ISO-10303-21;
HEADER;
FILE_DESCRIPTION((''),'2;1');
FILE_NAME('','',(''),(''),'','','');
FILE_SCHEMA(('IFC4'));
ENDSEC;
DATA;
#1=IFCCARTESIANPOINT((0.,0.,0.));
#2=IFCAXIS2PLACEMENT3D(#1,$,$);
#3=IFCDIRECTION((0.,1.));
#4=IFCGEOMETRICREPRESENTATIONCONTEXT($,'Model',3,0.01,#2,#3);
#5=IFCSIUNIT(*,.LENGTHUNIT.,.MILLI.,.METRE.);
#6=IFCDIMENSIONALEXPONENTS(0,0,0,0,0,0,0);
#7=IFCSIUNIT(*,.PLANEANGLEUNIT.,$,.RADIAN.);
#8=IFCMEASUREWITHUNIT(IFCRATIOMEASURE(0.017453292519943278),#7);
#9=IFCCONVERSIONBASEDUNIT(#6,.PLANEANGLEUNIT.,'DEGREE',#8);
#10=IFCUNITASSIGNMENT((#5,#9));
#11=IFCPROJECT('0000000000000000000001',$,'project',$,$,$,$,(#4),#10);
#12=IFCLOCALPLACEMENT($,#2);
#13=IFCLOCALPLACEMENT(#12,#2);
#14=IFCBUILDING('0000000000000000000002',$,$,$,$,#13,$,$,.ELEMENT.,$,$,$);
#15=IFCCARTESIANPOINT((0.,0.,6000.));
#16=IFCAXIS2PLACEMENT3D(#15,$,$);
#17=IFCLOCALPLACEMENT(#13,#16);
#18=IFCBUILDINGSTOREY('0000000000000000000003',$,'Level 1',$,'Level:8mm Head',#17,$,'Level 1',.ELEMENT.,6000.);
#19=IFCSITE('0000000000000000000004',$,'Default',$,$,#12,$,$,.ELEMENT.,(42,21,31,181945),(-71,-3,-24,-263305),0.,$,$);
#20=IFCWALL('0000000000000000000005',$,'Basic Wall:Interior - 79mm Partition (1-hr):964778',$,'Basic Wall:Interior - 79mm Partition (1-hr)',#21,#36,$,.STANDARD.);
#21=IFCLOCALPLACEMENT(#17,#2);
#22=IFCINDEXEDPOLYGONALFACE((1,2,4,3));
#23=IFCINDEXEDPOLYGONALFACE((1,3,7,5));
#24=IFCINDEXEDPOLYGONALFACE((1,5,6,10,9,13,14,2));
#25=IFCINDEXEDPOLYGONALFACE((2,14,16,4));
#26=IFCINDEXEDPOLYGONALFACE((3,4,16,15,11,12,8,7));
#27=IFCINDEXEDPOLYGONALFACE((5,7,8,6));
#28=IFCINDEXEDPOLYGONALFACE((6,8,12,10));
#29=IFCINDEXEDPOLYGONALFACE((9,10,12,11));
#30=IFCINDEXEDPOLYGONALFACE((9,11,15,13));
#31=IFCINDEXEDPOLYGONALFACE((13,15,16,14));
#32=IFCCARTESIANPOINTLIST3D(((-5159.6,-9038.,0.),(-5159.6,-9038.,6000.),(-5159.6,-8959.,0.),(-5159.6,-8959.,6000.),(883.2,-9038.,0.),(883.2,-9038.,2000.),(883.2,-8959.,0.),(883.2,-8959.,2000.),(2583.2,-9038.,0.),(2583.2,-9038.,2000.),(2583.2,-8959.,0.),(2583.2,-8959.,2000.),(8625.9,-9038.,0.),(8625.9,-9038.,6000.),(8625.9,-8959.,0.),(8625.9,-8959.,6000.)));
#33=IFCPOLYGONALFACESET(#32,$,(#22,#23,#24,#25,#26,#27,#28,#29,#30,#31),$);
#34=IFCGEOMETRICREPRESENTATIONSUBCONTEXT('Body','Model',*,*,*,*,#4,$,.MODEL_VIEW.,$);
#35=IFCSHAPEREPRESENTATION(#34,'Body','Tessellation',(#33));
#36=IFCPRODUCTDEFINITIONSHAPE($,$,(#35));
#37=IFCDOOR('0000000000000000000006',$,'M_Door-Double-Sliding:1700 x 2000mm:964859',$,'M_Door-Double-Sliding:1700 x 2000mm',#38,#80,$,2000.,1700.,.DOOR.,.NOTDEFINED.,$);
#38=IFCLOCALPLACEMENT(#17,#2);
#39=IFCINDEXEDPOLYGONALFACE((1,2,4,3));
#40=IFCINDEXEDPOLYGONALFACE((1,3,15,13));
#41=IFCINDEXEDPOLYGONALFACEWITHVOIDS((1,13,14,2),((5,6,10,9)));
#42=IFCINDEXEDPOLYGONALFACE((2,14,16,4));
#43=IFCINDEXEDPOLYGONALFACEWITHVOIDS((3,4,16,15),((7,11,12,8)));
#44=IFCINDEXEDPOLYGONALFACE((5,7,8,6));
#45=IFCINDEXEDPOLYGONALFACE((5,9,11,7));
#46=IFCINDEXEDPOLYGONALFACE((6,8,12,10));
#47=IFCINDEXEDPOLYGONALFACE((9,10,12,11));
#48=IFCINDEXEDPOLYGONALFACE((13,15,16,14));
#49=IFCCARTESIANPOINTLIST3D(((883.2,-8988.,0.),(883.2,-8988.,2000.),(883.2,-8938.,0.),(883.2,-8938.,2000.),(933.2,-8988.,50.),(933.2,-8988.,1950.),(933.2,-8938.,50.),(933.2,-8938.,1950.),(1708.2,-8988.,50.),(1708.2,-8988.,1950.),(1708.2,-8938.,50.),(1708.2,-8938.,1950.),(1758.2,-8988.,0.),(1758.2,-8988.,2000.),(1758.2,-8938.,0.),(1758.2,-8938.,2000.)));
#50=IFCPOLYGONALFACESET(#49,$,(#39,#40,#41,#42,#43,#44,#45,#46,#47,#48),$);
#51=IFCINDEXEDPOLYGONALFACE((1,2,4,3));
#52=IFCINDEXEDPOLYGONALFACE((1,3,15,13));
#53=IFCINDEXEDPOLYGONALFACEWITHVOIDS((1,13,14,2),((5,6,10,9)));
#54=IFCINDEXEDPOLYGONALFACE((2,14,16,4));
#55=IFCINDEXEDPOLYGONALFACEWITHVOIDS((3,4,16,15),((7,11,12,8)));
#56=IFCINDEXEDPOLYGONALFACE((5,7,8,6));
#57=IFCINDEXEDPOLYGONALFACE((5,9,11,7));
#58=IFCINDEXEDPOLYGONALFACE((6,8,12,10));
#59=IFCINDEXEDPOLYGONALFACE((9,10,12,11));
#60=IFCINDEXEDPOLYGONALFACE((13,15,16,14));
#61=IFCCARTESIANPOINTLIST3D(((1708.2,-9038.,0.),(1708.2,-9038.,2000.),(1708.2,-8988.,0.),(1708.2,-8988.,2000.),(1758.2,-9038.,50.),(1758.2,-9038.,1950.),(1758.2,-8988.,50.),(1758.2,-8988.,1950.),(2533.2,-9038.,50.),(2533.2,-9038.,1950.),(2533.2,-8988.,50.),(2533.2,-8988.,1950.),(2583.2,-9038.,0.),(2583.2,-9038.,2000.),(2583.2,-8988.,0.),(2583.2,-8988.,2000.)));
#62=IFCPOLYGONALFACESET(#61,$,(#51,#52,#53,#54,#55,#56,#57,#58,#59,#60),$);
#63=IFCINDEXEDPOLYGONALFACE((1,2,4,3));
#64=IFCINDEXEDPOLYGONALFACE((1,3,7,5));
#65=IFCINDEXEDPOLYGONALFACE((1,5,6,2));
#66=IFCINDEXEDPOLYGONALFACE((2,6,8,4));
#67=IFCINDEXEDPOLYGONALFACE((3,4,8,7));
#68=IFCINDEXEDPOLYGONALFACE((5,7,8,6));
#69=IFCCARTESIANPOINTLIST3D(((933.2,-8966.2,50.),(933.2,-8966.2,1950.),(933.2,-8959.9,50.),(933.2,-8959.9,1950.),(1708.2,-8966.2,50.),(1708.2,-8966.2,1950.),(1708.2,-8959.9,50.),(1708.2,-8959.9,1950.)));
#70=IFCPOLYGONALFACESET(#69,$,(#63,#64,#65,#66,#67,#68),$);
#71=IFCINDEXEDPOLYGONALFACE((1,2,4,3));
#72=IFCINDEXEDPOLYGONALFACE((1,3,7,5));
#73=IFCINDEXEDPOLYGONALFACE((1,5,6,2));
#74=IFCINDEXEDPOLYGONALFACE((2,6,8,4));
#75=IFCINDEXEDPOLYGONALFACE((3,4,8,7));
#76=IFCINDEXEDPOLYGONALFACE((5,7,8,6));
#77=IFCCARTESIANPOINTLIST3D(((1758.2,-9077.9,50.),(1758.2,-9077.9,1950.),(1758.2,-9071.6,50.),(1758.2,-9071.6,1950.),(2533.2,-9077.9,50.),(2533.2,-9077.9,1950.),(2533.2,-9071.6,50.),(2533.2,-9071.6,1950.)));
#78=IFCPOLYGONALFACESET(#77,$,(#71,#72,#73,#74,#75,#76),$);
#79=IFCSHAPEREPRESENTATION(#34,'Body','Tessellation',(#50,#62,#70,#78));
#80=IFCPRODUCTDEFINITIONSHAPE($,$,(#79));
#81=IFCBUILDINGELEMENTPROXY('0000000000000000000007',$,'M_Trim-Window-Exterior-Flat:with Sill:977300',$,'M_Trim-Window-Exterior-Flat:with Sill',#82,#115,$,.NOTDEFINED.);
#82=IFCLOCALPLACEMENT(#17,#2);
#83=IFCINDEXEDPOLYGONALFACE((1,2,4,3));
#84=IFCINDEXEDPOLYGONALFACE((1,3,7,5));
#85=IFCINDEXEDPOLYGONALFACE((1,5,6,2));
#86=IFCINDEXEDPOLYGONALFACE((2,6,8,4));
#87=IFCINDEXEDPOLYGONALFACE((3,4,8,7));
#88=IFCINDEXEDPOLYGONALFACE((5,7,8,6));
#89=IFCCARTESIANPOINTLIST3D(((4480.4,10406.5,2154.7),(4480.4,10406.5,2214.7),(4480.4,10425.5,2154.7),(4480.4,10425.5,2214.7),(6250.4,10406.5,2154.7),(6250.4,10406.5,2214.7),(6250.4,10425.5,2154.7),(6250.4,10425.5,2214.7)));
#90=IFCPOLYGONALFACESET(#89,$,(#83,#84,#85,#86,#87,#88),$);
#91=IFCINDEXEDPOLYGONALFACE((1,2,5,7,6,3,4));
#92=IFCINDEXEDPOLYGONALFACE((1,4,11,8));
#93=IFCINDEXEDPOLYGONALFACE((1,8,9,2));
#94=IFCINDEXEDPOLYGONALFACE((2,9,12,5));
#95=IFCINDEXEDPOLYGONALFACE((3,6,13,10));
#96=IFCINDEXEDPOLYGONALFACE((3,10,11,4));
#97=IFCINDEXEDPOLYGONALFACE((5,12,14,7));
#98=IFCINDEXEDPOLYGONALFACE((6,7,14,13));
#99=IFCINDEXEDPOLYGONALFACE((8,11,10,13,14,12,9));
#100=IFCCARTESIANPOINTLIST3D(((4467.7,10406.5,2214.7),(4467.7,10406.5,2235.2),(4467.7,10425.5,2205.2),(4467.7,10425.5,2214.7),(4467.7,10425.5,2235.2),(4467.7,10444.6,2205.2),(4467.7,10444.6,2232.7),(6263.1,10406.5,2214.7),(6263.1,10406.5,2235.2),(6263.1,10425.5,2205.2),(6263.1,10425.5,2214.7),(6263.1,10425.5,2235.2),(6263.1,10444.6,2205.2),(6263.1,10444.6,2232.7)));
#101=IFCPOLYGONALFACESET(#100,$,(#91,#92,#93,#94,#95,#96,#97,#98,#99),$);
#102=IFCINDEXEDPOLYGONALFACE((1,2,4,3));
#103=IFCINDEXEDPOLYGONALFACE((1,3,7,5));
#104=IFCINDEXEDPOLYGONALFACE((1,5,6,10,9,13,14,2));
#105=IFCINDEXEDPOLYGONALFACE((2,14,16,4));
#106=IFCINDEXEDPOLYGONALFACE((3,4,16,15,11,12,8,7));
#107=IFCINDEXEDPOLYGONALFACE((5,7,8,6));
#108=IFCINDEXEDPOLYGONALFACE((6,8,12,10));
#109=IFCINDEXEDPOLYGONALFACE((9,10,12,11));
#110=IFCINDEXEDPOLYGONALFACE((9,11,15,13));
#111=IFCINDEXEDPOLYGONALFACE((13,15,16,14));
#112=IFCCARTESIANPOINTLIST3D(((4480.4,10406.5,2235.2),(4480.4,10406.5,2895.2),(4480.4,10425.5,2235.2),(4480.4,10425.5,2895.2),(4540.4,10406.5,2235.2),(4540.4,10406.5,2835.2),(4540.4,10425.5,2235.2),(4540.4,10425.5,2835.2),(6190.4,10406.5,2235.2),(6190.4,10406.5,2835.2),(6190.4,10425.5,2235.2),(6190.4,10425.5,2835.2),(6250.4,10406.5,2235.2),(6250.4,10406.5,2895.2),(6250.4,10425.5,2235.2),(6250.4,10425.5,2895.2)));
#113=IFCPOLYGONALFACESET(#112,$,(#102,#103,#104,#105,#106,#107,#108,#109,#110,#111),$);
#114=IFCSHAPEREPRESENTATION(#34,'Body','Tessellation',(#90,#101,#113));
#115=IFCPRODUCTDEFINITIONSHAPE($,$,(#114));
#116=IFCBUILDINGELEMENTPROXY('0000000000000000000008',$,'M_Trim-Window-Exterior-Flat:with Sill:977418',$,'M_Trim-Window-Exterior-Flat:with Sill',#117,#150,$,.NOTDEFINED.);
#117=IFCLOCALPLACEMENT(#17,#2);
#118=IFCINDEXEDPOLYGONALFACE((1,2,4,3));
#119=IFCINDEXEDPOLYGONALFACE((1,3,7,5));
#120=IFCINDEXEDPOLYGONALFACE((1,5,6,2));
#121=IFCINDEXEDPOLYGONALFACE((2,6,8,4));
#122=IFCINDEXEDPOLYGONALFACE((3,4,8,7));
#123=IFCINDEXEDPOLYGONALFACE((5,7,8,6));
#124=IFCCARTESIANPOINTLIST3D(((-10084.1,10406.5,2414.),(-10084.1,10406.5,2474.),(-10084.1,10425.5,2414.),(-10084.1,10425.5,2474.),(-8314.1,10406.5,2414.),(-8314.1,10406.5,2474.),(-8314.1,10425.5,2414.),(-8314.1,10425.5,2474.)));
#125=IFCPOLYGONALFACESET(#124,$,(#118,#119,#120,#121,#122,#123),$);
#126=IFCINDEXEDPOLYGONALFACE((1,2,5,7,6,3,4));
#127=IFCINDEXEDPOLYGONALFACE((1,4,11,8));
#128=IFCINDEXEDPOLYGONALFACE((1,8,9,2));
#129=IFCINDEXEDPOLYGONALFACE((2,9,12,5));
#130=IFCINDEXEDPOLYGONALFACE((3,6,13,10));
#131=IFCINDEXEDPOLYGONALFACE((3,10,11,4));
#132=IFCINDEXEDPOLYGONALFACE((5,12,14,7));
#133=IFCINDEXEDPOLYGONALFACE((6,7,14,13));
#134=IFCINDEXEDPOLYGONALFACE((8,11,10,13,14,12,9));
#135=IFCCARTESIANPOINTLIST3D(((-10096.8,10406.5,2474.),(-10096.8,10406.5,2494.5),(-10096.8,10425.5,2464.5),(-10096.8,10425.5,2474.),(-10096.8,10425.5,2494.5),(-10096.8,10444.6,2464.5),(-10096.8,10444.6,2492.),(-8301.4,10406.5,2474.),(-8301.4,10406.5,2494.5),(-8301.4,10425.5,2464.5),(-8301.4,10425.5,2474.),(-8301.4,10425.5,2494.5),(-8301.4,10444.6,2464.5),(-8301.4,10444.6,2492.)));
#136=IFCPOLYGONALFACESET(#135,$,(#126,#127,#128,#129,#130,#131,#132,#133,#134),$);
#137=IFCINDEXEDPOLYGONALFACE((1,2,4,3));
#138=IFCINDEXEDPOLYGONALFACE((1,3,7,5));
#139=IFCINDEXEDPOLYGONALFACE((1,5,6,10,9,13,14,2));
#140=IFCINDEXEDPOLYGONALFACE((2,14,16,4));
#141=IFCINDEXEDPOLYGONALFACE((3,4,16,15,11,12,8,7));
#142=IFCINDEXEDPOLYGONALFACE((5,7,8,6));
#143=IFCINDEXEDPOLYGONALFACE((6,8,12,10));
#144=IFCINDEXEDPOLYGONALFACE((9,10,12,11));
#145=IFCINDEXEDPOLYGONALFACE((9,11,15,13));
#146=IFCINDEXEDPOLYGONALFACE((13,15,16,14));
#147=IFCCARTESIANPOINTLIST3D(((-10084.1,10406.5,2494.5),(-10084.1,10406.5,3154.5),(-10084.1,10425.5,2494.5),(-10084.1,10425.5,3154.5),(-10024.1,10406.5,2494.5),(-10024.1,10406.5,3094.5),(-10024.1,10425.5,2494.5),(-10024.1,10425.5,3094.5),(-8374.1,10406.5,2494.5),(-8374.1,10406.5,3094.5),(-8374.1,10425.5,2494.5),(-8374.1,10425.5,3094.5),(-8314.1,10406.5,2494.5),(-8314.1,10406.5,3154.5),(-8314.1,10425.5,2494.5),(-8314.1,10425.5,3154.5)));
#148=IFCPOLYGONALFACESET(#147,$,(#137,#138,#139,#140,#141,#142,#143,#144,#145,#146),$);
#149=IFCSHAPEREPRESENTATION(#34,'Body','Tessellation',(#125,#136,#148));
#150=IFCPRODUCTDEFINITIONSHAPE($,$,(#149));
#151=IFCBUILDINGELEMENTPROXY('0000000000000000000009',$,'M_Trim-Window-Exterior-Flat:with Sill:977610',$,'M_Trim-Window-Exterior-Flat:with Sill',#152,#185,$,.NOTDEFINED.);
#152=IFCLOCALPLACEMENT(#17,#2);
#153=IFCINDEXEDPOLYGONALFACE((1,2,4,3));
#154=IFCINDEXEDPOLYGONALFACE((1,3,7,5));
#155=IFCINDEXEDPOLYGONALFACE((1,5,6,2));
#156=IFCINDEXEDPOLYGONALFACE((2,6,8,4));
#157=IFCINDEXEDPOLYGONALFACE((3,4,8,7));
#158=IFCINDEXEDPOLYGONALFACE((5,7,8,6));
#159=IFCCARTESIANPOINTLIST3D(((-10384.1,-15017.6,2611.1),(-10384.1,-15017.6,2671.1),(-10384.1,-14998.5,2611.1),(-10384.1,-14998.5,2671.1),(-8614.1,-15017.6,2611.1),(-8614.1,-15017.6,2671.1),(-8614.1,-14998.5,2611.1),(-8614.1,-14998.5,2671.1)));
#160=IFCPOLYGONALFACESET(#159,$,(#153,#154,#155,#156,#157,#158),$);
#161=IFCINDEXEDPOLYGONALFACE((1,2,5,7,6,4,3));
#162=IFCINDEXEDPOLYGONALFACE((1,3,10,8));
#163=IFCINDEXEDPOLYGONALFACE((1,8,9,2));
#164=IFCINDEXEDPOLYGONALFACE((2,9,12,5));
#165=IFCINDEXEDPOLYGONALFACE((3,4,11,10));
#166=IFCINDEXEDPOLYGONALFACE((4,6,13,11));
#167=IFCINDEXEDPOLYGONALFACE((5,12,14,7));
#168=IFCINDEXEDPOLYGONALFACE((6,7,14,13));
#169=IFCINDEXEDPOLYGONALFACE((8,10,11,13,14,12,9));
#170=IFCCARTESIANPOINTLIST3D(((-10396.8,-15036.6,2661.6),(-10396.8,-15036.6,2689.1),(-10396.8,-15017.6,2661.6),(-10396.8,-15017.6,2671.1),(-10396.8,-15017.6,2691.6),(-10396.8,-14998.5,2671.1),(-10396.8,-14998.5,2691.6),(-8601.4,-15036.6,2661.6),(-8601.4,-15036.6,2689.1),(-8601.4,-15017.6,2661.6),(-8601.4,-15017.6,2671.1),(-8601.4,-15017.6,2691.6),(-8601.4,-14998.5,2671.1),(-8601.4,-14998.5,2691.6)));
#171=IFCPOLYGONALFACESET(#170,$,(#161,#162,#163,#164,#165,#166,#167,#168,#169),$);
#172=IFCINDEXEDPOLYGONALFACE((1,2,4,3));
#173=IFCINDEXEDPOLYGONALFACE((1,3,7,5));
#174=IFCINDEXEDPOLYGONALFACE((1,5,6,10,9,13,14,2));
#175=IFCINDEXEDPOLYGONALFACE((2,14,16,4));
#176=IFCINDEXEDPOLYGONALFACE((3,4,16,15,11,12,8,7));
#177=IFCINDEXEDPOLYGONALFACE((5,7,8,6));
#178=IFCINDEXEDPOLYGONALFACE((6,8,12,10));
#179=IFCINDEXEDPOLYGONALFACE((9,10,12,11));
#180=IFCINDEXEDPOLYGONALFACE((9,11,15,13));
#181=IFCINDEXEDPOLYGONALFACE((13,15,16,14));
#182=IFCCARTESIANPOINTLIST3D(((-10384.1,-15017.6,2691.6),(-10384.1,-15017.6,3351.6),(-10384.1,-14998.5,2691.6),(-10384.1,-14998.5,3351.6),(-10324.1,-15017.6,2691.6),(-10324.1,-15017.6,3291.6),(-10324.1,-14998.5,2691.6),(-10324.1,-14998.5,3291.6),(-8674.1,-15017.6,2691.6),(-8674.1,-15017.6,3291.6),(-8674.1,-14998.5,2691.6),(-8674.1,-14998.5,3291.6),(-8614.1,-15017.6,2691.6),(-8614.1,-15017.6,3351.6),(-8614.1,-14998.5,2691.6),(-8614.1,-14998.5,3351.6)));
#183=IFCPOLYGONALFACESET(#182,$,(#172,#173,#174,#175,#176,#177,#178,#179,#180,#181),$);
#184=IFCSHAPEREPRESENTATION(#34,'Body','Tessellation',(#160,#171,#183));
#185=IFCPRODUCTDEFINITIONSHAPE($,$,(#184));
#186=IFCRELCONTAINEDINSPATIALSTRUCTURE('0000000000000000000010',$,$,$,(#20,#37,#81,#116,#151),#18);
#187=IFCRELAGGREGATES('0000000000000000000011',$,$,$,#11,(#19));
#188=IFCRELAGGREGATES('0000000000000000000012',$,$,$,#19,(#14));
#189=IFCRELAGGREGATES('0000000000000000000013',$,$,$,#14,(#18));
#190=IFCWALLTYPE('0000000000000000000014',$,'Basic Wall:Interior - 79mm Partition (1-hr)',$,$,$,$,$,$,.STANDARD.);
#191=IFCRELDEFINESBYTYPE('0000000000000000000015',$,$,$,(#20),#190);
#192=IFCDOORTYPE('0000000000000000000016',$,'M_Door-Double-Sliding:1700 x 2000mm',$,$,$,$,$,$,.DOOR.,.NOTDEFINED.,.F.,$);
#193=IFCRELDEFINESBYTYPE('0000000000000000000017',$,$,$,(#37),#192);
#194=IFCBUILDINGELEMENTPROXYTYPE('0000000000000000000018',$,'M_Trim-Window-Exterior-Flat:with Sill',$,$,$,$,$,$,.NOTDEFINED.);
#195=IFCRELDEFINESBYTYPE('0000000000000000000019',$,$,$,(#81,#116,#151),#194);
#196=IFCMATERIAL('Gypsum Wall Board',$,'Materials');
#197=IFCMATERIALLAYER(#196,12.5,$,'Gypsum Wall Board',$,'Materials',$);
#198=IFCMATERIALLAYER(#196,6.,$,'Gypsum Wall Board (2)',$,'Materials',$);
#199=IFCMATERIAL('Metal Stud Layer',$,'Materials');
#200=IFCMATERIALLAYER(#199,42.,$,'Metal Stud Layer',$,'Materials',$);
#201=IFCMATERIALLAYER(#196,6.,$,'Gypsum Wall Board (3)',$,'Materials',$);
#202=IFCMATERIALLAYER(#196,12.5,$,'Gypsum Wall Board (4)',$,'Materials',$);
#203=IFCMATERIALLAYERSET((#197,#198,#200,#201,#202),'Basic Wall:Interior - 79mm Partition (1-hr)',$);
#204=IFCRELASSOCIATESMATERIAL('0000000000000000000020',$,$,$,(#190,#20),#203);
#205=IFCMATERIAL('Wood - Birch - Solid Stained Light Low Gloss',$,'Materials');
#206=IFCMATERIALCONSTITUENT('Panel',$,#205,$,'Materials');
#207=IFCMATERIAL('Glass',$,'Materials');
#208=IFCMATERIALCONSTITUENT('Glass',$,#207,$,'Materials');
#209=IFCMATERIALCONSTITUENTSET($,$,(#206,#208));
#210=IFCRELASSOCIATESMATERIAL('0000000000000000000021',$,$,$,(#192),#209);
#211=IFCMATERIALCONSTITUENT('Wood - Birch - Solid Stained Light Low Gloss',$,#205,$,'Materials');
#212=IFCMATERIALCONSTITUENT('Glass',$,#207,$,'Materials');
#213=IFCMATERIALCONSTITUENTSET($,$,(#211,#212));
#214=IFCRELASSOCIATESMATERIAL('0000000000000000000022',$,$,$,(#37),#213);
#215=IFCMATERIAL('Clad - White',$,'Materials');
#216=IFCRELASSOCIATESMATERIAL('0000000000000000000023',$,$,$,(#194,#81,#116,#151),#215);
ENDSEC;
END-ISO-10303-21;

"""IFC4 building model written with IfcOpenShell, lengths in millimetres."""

from ifc_helpers import new_model, entity, si_unit, converted_unit, direction, frame, frame_2d, origin, origin_2d_with_axis, place, context, subcontext, project, spatial, polyline, rectangle, outline, extrude, source, transform, mapped, material, layer, layer_set, layer_usage, constituent, constituent_set, type_object, type_shapes, element, fill, save


model = new_model("IFC4")

# Units and contexts
model_context = context("Model", 3, precision=0.01, world=origin(), true_north=direction((0.0, 1.0)))
body_context = subcontext(model_context, "Body", "Model", "MODEL_VIEW")
ifc_project = project(units=[si_unit("LENGTHUNIT", "METRE", prefix="MILLI"), converted_unit("PLANEANGLEUNIT", "DEGREE", entity("IfcRatioMeasure", 0.017453292519943278), si_unit("PLANEANGLEUNIT", "RADIAN"), dimensions=[0, 0, 0, 0, 0, 0, 0])], contexts=[model_context])

# Site, building, storey
site_placement = place(None, origin())
site = spatial("IfcSite", under=ifc_project, at=site_placement, Name="Default", CompositionType="ELEMENT", RefLatitude=(42, 21, 31, 181945), RefLongitude=(-71, -3, -24, -263305), RefElevation=0.0)
building_placement = place(site_placement, origin())
building = spatial("IfcBuilding", under=site, at=building_placement, CompositionType="ELEMENT")
storey_placement = place(building_placement, frame((0.0, 0.0, 6000.0)))
storey = spatial("IfcBuildingStorey", under=building, at=storey_placement, Name="Level 1", ObjectType="Level:8mm Head", LongName="Level 1", CompositionType="ELEMENT", Elevation=6000.0)

# Shared definitions
ifc_material_1 = material(Name="Gypsum Wall Board", Category="Materials")
ifc_layer_1 = layer(ifc_material_1, 12.5, Name="Gypsum Wall Board", Category="Materials")
ifc_layer_2 = layer(ifc_material_1, 6.0, Name="Gypsum Wall Board (2)", Category="Materials")
ifc_material_2 = material(Name="Metal Stud Layer", Category="Materials")
ifc_layer_3 = layer(ifc_material_2, 42.0, Name="Metal Stud Layer", Category="Materials")
ifc_layer_4 = layer(ifc_material_1, 6.0, Name="Gypsum Wall Board (3)", Category="Materials")
ifc_layer_5 = layer(ifc_material_1, 12.5, Name="Gypsum Wall Board (4)", Category="Materials")
ifc_layer_set_1 = layer_set([ifc_layer_1, ifc_layer_2, ifc_layer_3, ifc_layer_4, ifc_layer_5], Name="Basic Wall:Interior - 79mm Partition (1-hr)")
ifc_layer_usage_1 = layer_usage(ifc_layer_set_1, "AXIS2", "NEGATIVE", 39.5)
wall_type = type_object("IfcWallType", Name="Basic Wall:Interior - 79mm Partition (1-hr)", PredefinedType="STANDARD", material=ifc_layer_set_1)

# Wall, opening, door
ifc_material_3 = material(Name="Wood - Birch - Solid Stained Light Low Gloss", Category="Materials")
ifc_material_4 = material(Name="Glass", Category="Materials")
ifc_constituent_1 = constituent(ifc_material_3, Name="Panel", Category="Materials")
ifc_constituent_2 = constituent(ifc_material_4, Name="Glass", Category="Materials")
ifc_constituent_set_1 = constituent_set(constituents=[ifc_constituent_1, ifc_constituent_2])
door_type = type_object("IfcDoorType", Name="M_Door-Double-Sliding:1700 x 2000mm", OperationType="NOTDEFINED", ParameterTakesPrecedence=False, PredefinedType="DOOR", material=ifc_constituent_set_1)
shared_shape_1 = source(origin(), body_context, "Body", "SweptSolid", [
    extrude(outline(polyline([(-437.5, -1000.0), (437.5, -1000.0), (437.5, 1000.0), (-437.5, 1000.0), (-437.5, -1000.0)]), holes=[polyline([(-387.5, -950.0), (-387.5, 950.0), (387.5, 950.0), (387.5, -950.0), (-387.5, -950.0)])]), frame((1262.5, -21.0, 1000.0), z_axis=(0.0, 1.0, 0.0), x_axis=(1.0, 0.0, 0.0)), (0.0, 0.0, 1.0), 50.0),
    extrude(outline(polyline([(-1000.0, -437.5), (1000.0, -437.5), (1000.0, 437.5), (-1000.0, 437.5), (-1000.0, -437.5)]), holes=[polyline([(-950.0, -387.5), (-950.0, 387.5), (950.0, 387.5), (950.0, -387.5), (-950.0, -387.5)])]), frame((437.5, 29.0, 1000.0), z_axis=(0.0, 1.0, 0.0), x_axis=(0.0, 0.0, -1.0)), (0.0, 0.0, 1.0), 50.0),
    extrude(rectangle(XDim=6.3, YDim=775.0, at=frame_2d((0.0, 0.0), x_axis=(1.0, 0.0))), frame((1262.5, 4.0, 50.0), z_axis=(0.0, 0.0, 1.0), x_axis=(0.0, -1.0, 0.0)), (0.0, 0.0, 1.0), 1900.0),
    extrude(rectangle(XDim=6.4, YDim=775.0, at=origin_2d_with_axis()), frame((437.5, 115.7, 50.0), z_axis=(0.0, 0.0, 1.0), x_axis=(0.0, 1.0, 0.0)), (0.0, 0.0, 1.0), 1900.0),
])
type_shapes(door_type, [shared_shape_1])
wall_1_placement = place(storey_placement, frame((-5159.6, -8998.5, 0.0)))
wall_1 = element("IfcWall", 1, at=wall_1_placement, inside=storey, type_object=wall_type, material=ifc_layer_usage_1, Name="Basic Wall:Interior - 79mm Partition (1-hr):964778", ObjectType="Basic Wall:Interior - 79mm Partition (1-hr)", PredefinedType="STANDARD", context=body_context, shape_type="SweptSolid", body=[
    extrude(rectangle(XDim=13785.5, YDim=79.0, at=frame_2d((6892.8, 0.0), x_axis=(1.0, 0.0))), origin(), (0.0, 0.0, 1.0), 6000.0),
])
opening_1_placement = place(wall_1_placement, frame((7742.8, 39.5, 0.0)))
opening_1 = element("IfcOpeningElement", 2, at=opening_1_placement, cuts=wall_1, PredefinedType="OPENING", context=body_context, shape_type="SweptSolid", body=[
    extrude(rectangle(XDim=2000.0, YDim=1700.0, at=frame_2d((1000.0, 850.0), x_axis=(-1.0, 0.0))), frame((0.0, 0.0, 0.0), z_axis=(0.0, -1.0, 0.0), x_axis=(0.0, 0.0, 1.0)), (0.0, 0.0, 1.0), 79.0),
])
ifc_constituent_3 = constituent(ifc_material_3, Name="Wood - Birch - Solid Stained Light Low Gloss", Category="Materials")
ifc_constituent_4 = constituent(ifc_material_4, Name="Glass", Category="Materials")
ifc_constituent_set_2 = constituent_set(constituents=[ifc_constituent_3, ifc_constituent_4])
door_1_placement = place(opening_1_placement, frame((0.0, 0.0, 0.0), z_axis=(0.0, 0.0, 1.0), x_axis=(-1.0, 0.0, 0.0)))
door_1 = element("IfcDoor", 3, at=door_1_placement, inside=storey, type_object=door_type, material=ifc_constituent_set_2, Name="M_Door-Double-Sliding:1700 x 2000mm:964859", ObjectType="M_Door-Double-Sliding:1700 x 2000mm", OperationType="NOTDEFINED", OverallHeight=2000.0, OverallWidth=1700.0, PredefinedType="DOOR", context=body_context, shape_type="MappedRepresentation", body=[
    mapped(shared_shape_1, transform((0.0, 0.0, 0.0), scale=1.0)),
])
fill(opening_1, door_1)

# Building element proxies
ifc_material_5 = material(Name="Clad - White", Category="Materials")
building_element_proxy_type_1 = type_object("IfcBuildingElementProxyType", Name="M_Trim-Window-Exterior-Flat:with Sill", PredefinedType="NOTDEFINED", material=ifc_material_5)
shared_shape_2 = source(origin(), body_context, "Body", "SweptSolid", [
    extrude(rectangle(XDim=1770.0, YDim=60.0, at=frame_2d((0.0, 0.0), x_axis=(1.0, 0.0))), frame((0.0, -650.4, 0.0), z_axis=(0.0, 0.0, 1.0), x_axis=(-1.0, 0.0, 0.0)), (0.0, 0.0, 1.0), 19.0),
    extrude(outline(polyline([(-19.0, -15.2), (0.0, -15.2), (0.0, -5.7), (19.0, -5.7), (19.0, 14.8), (0.0, 14.8), (-19.0, 12.3), (-19.0, -15.2)])), frame((-897.7, -614.8, 19.0), z_axis=(1.0, 0.0, 0.0), x_axis=(0.0, 0.0, -1.0)), (0.0, 0.0, 1.0), 1795.4),
    extrude(outline(polyline([(-345.0, -885.0), (315.0, -885.0), (315.0, -825.0), (-285.0, -825.0), (-285.0, 825.0), (315.0, 825.0), (315.0, 885.0), (-345.0, 885.0), (-345.0, -885.0)])), frame((0.0, -285.0, 0.0), z_axis=(0.0, 0.0, 1.0), x_axis=(0.0, -1.0, 0.0)), (0.0, 0.0, 1.0), 19.0),
])
type_shapes(building_element_proxy_type_1, [shared_shape_2])
for number, where, z_axis, x_axis, name in (
    (4, (5365.4, 10406.5, 2835.2), (0.0, 1.0, 0.0), (-1.0, 0.0, 0.0), "M_Trim-Window-Exterior-Flat:with Sill:977300"),
    (5, (-9199.1, 10406.5, 3094.5), (0.0, 1.0, 0.0), (-1.0, 0.0, 0.0), "M_Trim-Window-Exterior-Flat:with Sill:977418"),
    (6, (-9499.1, -14998.5, 3291.6), (0.0, -1.0, 0.0), (1.0, 0.0, 0.0), "M_Trim-Window-Exterior-Flat:with Sill:977610"),
):
    element("IfcBuildingElementProxy", number, at=place(storey_placement, frame(where, z_axis=z_axis, x_axis=x_axis)), inside=storey, type_object=building_element_proxy_type_1, material=ifc_material_5, Name=name, ObjectType="M_Trim-Window-Exterior-Flat:with Sill", PredefinedType="NOTDEFINED", context=body_context, shape_type="MappedRepresentation", body=[
        mapped(shared_shape_2, transform((0.0, 0.0, 0.0), scale=1.0)),
    ])

save(model, "model.ifc")
